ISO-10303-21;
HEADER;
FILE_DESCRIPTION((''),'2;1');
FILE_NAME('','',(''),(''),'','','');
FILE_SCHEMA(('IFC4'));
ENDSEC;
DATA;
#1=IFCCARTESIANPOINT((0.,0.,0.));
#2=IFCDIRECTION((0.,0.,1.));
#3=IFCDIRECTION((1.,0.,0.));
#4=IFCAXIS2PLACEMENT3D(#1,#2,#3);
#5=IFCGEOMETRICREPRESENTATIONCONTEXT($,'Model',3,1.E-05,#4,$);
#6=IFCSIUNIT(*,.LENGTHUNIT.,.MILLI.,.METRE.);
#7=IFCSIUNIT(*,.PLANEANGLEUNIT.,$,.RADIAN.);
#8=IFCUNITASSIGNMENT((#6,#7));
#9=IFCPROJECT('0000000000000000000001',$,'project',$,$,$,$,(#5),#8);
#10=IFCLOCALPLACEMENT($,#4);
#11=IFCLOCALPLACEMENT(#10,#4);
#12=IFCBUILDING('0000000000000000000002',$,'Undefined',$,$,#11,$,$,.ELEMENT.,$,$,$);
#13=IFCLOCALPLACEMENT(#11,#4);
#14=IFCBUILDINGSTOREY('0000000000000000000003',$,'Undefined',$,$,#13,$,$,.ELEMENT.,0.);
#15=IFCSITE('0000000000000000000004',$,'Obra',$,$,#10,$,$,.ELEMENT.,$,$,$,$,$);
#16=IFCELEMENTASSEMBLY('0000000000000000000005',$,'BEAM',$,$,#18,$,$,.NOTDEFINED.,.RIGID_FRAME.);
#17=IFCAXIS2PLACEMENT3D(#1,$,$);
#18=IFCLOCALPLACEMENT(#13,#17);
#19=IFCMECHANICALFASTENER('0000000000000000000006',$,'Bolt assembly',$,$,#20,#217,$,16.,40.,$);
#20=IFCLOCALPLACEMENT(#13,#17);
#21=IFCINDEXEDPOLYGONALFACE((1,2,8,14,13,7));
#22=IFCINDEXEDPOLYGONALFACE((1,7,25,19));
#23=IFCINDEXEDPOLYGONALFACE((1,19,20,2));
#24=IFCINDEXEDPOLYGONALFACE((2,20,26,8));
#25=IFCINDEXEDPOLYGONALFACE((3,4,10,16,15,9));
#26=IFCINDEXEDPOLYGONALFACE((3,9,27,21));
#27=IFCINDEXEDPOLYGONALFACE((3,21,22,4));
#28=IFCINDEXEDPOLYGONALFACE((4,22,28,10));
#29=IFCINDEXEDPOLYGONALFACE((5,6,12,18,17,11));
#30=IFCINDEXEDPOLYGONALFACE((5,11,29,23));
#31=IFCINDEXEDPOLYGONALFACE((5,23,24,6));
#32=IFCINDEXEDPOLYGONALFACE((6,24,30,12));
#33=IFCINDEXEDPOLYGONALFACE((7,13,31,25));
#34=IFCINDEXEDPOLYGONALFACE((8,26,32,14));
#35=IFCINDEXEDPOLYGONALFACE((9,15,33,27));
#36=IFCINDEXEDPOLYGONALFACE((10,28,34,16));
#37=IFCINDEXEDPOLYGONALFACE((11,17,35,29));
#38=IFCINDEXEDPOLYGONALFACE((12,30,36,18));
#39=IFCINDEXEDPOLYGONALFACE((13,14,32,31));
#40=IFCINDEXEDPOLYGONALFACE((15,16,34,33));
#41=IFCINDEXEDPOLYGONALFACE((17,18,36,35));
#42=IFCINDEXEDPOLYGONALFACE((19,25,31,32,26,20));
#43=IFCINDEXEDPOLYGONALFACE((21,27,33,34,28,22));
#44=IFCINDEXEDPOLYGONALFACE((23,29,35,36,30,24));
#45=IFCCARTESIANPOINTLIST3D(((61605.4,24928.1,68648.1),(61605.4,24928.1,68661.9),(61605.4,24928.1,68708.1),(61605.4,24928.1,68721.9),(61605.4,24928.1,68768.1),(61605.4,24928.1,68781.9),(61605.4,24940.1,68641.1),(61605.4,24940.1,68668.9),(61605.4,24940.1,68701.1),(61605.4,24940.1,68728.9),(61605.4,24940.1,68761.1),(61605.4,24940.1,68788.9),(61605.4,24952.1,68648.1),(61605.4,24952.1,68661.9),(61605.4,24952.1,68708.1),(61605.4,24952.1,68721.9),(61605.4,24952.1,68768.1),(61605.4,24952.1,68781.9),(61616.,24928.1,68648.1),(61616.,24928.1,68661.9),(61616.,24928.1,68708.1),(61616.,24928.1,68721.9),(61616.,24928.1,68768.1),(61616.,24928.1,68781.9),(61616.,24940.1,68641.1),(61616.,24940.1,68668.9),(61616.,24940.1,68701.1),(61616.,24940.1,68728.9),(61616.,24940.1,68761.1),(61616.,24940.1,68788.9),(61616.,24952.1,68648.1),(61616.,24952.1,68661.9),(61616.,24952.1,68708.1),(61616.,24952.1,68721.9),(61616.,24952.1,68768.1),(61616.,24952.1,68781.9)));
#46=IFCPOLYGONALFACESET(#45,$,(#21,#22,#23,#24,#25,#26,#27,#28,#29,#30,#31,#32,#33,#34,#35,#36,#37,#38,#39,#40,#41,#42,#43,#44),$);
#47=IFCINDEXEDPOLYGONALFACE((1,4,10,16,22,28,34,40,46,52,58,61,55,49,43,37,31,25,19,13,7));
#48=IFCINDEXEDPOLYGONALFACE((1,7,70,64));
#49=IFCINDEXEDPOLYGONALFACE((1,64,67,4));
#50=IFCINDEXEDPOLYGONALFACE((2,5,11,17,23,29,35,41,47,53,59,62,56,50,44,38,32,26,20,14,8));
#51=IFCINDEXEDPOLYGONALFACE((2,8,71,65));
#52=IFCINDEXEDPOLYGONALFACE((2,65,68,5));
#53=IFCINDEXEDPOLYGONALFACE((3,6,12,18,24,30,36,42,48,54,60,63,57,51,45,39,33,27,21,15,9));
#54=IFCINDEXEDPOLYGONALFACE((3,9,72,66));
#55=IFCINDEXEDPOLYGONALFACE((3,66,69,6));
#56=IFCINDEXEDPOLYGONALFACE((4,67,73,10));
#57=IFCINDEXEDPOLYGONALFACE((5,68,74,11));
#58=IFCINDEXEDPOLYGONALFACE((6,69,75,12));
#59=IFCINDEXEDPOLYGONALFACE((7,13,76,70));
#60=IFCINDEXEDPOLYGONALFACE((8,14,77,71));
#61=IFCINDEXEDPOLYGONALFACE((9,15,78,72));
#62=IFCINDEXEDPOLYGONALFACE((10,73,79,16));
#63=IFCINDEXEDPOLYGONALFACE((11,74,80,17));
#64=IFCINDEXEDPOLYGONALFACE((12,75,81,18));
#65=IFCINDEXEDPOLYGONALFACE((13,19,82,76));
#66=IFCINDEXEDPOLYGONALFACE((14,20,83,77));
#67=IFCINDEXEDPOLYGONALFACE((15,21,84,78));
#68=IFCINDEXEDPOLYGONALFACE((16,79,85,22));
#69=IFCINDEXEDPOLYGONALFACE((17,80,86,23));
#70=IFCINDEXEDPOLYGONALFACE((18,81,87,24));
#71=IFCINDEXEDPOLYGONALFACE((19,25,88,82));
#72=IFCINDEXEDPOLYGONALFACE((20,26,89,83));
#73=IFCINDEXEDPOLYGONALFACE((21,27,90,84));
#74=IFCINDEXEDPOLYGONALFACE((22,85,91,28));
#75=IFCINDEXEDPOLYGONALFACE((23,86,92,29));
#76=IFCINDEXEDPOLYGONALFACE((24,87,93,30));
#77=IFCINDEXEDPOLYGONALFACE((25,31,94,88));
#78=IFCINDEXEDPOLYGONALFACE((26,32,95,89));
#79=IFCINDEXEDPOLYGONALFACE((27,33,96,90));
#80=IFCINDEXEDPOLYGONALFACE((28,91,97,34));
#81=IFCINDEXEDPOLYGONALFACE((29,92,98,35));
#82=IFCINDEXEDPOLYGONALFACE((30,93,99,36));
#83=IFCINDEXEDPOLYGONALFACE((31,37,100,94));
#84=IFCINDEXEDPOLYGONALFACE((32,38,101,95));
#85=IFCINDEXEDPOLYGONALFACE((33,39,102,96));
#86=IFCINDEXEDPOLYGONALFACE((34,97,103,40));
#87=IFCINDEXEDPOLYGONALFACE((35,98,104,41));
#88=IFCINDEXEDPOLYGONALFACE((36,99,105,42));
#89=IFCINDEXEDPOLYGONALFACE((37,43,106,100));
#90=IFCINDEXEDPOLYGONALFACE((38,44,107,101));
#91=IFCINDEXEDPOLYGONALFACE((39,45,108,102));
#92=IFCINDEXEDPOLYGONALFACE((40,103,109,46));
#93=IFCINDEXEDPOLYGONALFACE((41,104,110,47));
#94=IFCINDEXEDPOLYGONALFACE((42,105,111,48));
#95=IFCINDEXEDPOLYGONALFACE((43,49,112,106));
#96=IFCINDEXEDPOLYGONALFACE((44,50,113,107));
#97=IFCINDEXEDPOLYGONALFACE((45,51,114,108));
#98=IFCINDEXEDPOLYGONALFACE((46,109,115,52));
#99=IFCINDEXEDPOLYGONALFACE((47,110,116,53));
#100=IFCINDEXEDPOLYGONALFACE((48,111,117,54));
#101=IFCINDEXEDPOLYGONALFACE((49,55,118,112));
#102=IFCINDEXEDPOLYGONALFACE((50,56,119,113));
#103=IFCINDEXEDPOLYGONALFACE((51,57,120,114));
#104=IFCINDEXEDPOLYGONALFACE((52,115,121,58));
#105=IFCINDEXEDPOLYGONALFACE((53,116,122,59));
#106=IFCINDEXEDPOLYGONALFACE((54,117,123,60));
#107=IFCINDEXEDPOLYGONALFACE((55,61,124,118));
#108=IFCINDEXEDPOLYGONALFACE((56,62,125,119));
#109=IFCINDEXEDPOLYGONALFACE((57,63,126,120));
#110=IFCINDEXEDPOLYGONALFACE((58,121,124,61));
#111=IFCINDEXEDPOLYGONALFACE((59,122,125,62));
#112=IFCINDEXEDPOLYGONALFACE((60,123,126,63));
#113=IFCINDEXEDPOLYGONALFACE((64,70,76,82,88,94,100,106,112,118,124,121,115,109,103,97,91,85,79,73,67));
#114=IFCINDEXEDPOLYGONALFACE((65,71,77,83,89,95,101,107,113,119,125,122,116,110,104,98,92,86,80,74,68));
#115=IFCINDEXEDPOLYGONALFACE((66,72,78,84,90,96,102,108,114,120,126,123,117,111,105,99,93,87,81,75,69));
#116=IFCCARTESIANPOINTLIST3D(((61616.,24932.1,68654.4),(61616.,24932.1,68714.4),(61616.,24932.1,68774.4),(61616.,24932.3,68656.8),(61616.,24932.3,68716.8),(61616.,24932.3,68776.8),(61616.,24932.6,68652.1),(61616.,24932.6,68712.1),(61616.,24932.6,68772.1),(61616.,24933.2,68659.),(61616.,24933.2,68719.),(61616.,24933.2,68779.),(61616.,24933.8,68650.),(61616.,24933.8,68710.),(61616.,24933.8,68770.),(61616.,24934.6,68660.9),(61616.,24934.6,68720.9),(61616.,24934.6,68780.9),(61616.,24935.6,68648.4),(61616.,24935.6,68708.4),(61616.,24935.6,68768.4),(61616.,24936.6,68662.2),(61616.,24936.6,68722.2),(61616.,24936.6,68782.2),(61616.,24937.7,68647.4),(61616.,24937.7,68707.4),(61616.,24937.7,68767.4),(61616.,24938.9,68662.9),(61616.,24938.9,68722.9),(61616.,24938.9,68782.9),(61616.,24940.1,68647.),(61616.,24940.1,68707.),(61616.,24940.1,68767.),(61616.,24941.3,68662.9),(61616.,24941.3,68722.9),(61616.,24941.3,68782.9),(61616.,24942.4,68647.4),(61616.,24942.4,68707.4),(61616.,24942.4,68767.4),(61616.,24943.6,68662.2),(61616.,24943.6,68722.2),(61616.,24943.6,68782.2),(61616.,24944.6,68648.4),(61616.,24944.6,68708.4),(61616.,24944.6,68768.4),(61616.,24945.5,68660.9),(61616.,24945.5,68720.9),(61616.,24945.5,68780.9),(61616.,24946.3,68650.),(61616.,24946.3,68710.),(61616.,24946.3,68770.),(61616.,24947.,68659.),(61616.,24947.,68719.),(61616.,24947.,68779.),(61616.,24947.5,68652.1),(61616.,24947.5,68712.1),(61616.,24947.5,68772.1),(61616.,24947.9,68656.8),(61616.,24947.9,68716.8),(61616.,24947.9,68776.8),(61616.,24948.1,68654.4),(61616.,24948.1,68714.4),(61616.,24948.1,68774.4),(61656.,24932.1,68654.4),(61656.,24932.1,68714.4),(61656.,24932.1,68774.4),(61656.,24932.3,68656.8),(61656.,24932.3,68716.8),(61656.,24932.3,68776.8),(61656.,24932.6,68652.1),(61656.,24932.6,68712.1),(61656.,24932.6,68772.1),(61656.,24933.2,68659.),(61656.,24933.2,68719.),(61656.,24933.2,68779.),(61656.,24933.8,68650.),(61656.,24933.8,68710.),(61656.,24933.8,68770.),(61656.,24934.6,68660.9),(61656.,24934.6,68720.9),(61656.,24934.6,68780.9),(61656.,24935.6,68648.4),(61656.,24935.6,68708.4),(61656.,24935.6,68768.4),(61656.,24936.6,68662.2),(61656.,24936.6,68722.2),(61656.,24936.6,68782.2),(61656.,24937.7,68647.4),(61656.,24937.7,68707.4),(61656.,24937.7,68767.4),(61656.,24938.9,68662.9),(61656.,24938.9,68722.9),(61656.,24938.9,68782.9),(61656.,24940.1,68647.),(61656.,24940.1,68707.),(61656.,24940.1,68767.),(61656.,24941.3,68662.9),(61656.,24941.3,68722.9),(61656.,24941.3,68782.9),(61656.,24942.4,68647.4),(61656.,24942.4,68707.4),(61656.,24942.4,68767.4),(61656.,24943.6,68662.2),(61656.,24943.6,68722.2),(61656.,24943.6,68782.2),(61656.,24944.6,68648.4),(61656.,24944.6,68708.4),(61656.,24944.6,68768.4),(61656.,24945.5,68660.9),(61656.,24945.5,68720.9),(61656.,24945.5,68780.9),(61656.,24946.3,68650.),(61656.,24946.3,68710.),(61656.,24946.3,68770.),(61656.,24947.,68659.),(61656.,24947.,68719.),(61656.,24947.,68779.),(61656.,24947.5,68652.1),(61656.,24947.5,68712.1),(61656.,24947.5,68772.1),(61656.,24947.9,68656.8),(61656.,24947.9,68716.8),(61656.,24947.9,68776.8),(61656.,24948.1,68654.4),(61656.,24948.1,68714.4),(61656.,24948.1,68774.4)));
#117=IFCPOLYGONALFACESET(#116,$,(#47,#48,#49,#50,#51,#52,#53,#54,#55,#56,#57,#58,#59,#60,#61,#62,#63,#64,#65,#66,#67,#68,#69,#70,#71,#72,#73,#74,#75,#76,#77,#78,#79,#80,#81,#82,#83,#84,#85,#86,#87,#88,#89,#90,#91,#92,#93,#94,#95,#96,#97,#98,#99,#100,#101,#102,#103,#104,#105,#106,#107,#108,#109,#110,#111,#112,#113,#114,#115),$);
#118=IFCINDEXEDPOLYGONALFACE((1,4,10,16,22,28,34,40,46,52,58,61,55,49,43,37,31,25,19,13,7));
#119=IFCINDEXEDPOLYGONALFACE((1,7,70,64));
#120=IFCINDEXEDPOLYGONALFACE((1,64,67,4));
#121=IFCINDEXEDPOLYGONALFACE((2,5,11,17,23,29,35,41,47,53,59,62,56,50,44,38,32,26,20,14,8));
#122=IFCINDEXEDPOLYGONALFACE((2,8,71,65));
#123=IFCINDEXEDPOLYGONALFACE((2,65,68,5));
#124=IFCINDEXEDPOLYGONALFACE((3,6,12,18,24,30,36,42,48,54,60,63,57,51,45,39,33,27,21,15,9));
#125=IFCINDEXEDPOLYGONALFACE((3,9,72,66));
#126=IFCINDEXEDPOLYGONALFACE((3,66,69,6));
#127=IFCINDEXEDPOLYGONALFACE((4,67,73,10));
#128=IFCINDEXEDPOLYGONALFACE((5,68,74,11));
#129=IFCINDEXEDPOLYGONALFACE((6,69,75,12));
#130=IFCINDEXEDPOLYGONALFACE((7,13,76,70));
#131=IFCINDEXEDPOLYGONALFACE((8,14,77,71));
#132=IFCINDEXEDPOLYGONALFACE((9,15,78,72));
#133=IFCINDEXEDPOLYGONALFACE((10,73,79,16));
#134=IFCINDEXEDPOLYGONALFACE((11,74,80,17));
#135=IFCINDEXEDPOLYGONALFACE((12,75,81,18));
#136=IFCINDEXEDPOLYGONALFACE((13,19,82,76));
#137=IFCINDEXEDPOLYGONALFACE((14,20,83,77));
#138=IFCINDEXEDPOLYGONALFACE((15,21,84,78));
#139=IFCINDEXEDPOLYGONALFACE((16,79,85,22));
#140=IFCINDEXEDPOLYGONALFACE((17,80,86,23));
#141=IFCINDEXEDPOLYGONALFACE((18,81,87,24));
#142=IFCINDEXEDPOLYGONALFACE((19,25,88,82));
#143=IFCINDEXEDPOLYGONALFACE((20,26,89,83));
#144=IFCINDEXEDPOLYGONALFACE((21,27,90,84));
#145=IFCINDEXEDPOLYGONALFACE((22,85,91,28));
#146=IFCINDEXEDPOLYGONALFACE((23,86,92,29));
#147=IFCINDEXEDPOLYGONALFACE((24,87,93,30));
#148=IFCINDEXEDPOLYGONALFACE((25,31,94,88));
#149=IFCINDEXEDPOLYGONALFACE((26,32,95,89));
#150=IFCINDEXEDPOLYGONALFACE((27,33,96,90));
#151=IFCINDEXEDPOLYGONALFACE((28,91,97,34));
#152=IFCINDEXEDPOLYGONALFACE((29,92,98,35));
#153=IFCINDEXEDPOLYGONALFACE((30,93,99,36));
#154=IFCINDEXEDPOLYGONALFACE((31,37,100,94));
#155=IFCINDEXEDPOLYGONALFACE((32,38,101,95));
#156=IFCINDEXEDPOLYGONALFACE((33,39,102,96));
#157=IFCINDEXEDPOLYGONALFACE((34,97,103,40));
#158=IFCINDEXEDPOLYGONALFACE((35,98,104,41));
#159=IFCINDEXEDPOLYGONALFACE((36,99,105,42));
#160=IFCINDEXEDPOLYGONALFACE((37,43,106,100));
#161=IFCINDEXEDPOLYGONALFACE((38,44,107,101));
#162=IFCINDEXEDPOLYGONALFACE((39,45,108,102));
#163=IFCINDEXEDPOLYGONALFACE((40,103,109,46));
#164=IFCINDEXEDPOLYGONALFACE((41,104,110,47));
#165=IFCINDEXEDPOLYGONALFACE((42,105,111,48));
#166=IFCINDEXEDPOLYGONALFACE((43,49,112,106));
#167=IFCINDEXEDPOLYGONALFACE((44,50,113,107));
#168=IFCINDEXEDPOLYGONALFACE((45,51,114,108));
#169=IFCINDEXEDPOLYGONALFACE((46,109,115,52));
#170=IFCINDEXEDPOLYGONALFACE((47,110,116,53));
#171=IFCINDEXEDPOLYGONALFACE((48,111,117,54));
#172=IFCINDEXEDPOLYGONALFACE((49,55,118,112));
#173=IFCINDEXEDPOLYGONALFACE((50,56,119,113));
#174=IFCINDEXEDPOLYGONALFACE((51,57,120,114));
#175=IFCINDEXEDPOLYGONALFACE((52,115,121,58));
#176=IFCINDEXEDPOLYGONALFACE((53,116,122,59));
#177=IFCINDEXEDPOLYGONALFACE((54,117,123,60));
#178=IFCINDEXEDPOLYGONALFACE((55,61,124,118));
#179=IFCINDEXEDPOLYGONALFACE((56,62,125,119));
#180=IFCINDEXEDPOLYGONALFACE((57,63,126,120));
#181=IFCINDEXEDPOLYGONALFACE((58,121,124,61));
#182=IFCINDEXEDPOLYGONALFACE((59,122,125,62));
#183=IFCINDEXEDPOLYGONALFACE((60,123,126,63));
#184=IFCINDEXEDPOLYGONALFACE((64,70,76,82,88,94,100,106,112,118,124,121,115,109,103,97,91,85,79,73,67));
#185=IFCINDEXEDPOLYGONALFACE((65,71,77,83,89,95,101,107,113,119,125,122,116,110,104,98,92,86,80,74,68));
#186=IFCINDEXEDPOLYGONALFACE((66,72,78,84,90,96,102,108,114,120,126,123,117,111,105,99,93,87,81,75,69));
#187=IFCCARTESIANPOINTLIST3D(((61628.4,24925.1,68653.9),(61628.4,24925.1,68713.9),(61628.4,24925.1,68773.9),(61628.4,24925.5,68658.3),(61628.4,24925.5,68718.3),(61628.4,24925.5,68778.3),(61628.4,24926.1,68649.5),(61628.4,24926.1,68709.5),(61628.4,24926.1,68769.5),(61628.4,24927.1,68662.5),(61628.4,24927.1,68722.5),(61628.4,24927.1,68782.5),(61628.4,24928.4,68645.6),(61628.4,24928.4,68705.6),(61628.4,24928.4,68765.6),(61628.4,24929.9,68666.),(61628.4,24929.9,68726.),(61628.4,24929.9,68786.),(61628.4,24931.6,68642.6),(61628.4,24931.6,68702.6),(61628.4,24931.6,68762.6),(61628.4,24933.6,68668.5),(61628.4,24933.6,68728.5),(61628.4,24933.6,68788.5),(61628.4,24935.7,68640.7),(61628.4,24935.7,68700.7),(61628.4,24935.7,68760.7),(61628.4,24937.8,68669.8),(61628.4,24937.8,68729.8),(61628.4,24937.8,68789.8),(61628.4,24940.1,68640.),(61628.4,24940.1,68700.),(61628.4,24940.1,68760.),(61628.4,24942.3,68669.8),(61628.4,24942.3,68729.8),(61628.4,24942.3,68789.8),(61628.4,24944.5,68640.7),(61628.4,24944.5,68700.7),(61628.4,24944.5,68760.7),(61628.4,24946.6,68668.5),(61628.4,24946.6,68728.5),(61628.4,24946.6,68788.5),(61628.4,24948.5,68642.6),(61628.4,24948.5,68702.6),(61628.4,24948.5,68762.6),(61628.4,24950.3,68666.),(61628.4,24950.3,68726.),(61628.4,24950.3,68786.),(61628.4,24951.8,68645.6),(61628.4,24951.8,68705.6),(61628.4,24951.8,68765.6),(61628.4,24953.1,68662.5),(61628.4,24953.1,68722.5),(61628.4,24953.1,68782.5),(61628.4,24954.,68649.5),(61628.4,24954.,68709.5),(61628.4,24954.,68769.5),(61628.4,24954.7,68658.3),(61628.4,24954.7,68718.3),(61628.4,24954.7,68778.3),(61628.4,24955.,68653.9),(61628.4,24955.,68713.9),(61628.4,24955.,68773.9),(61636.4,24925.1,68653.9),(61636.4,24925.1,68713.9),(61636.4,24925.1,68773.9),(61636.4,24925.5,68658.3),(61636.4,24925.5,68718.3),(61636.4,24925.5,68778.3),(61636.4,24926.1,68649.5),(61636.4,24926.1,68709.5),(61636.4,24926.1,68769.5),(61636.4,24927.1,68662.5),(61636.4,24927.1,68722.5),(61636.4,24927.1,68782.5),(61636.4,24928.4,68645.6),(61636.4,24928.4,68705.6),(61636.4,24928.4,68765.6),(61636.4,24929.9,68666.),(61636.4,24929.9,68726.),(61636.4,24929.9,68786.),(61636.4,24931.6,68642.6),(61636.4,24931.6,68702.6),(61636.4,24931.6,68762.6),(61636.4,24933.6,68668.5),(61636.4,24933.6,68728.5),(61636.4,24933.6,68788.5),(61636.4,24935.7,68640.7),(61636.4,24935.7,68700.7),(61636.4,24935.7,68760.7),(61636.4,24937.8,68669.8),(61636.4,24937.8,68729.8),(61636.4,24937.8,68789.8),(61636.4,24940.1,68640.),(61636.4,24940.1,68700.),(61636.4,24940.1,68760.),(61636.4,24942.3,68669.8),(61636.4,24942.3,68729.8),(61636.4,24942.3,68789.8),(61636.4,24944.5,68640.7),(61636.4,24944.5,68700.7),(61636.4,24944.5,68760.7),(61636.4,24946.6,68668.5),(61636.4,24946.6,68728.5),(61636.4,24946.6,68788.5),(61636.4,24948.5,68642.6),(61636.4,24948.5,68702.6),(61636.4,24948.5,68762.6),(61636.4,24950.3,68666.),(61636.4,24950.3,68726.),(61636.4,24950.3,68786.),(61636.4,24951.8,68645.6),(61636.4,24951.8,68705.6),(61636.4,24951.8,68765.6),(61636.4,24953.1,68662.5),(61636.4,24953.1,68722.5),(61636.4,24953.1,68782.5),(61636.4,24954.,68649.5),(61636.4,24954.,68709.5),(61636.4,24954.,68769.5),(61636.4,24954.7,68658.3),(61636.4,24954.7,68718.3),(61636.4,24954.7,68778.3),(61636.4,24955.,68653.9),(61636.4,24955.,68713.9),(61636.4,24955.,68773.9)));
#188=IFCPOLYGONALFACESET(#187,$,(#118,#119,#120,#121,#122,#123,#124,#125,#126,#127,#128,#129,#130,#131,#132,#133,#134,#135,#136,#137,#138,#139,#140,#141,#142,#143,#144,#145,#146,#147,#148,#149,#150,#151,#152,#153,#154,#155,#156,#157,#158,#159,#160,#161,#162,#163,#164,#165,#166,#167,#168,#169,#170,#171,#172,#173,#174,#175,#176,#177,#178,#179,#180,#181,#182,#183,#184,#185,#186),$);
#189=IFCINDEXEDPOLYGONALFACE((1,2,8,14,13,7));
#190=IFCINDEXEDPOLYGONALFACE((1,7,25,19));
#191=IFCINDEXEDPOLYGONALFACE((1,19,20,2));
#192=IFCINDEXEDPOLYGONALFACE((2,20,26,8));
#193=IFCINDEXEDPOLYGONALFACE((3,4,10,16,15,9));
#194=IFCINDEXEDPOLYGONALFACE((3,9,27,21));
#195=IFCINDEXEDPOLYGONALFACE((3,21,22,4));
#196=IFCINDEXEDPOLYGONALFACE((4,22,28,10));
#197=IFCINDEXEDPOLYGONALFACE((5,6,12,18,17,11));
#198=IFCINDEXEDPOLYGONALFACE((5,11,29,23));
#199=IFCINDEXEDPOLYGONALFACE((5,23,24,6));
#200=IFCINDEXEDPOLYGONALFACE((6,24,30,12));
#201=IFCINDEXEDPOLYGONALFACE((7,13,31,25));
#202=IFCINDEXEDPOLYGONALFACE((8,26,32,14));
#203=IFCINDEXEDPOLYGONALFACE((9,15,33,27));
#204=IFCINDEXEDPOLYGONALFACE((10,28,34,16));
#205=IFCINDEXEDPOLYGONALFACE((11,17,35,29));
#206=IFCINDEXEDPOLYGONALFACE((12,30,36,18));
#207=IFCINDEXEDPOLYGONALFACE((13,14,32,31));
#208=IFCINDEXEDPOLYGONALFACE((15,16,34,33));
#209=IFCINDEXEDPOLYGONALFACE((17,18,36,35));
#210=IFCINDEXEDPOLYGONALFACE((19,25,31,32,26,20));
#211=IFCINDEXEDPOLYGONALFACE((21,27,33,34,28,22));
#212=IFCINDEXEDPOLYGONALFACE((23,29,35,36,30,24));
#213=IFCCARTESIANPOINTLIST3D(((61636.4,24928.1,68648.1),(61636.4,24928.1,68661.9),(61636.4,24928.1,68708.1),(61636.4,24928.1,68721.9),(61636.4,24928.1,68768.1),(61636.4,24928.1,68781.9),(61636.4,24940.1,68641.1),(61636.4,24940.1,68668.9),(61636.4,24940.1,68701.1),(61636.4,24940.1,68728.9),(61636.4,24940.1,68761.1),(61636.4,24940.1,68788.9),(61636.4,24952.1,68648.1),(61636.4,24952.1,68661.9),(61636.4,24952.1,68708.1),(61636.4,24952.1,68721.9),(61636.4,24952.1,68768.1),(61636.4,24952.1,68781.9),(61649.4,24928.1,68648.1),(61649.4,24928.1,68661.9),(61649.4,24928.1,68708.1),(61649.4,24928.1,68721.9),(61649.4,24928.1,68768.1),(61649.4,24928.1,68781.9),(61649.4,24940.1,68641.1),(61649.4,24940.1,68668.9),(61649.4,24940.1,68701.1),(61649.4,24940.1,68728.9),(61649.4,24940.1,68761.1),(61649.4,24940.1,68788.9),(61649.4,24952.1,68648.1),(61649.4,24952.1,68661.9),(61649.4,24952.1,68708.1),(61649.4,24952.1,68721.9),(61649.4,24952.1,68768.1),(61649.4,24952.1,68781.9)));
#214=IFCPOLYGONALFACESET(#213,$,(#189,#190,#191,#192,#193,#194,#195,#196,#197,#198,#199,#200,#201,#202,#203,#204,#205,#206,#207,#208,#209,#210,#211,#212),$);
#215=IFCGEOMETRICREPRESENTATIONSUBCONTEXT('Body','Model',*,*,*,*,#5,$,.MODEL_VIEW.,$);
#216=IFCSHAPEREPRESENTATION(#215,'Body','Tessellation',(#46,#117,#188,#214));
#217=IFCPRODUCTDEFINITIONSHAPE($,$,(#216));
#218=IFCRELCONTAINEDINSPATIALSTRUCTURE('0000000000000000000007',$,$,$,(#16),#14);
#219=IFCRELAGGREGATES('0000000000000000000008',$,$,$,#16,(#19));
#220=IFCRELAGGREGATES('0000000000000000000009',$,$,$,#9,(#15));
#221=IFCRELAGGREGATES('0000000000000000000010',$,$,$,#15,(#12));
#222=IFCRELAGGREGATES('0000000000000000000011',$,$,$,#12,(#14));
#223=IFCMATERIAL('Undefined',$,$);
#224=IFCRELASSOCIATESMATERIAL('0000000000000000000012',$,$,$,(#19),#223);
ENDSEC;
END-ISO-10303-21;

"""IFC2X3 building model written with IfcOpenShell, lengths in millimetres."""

from ifc_helpers import new_model, si_unit, frame, origin_with_axes, origin_2d_with_axis, place, context, subcontext, project, spatial, polyline, circle, outline, extrude, source, transform, mapped, material, element, aggregate, save


model = new_model("IFC2X3")

# Units and contexts
model_context = context("Model", 3, precision=1e-05, world=origin_with_axes())
body_context = subcontext(model_context, "Body", "Model", "MODEL_VIEW")
ifc_project = project(units=[si_unit("LENGTHUNIT", "METRE", prefix="MILLI"), si_unit("PLANEANGLEUNIT", "RADIAN")], contexts=[model_context])

# Site, building, storey
site_placement = place(None, origin_with_axes())
site = spatial("IfcSite", under=ifc_project, at=site_placement, Name="Obra", CompositionType="ELEMENT")
building_placement = place(site_placement, origin_with_axes())
building = spatial("IfcBuilding", under=site, at=building_placement, Name="Undefined", CompositionType="ELEMENT")
storey_placement = place(building_placement, origin_with_axes())
storey = spatial("IfcBuildingStorey", under=building, at=storey_placement, Name="Undefined", CompositionType="ELEMENT", Elevation=0.0)

# Element assembly, mechanical fastener
assembly_1_placement = place(storey_placement, origin_with_axes())
assembly_1 = element("IfcElementAssembly", 1, at=assembly_1_placement, inside=storey, Name="BEAM", AssemblyPlace="NOTDEFINED", PredefinedType="RIGID_FRAME")
ifc_material_1 = material(Name="Undefined")
shared_shape_1 = source(origin_with_axes(), body_context, "Body", "SweptSolid", [
    extrude(outline(polyline([(13.9, 0.0), (6.9, 12.0), (-6.9, 12.0), (-13.9, 0.0), (-6.9, -12.0), (6.9, -12.0), (13.9, 0.0)])), frame((0.0, -19.7, 0.0), z_axis=(0.0, 1.0, 0.0), x_axis=(1.0, 0.0, 0.0)), (0.0, 0.0, 1.0), 10.6),
    extrude(circle(Radius=8.0, at=origin_2d_with_axis()), frame((0.0, -9.1, 0.0), z_axis=(0.0, 1.0, 0.0), x_axis=(1.0, 0.0, 0.0)), (0.0, 0.0, 1.0), 40.0),
    extrude(circle(Radius=15.0, at=origin_2d_with_axis()), frame((0.0, 3.3, 0.0), z_axis=(0.0, 1.0, 0.0), x_axis=(1.0, 0.0, 0.0)), (0.0, 0.0, 1.0), 8.0),
    extrude(outline(polyline([(13.9, 0.0), (6.9, 12.0), (-6.9, 12.0), (-13.9, 0.0), (-6.9, -12.0), (6.9, -12.0), (13.9, 0.0)])), frame((0.0, 11.3, 0.0), z_axis=(0.0, 1.0, 0.0), x_axis=(1.0, 0.0, 0.0)), (0.0, 0.0, 1.0), 13.0),
])
mechanical_fastener_1_placement = place(assembly_1_placement, frame((61625.1, 24990.1, 68835.0), z_axis=(0.000002, -1.0, 0.0), x_axis=(0.0, 0.0, -1.0)))
mechanical_fastener_1 = element("IfcMechanicalFastener", 2, at=mechanical_fastener_1_placement, material=ifc_material_1, Name="Bolt assembly", NominalDiameter=16.0, NominalLength=40.0, context=body_context, shape_type="MappedRepresentation", body=[
    mapped(shared_shape_1, transform((60.0, 0.0, 50.0))),
    mapped(shared_shape_1, transform((120.0, 0.0, 50.0))),
    mapped(shared_shape_1, transform((180.0, 0.0, 50.0))),
])
aggregate(assembly_1, [mechanical_fastener_1])

save(model, "model.ifc")
